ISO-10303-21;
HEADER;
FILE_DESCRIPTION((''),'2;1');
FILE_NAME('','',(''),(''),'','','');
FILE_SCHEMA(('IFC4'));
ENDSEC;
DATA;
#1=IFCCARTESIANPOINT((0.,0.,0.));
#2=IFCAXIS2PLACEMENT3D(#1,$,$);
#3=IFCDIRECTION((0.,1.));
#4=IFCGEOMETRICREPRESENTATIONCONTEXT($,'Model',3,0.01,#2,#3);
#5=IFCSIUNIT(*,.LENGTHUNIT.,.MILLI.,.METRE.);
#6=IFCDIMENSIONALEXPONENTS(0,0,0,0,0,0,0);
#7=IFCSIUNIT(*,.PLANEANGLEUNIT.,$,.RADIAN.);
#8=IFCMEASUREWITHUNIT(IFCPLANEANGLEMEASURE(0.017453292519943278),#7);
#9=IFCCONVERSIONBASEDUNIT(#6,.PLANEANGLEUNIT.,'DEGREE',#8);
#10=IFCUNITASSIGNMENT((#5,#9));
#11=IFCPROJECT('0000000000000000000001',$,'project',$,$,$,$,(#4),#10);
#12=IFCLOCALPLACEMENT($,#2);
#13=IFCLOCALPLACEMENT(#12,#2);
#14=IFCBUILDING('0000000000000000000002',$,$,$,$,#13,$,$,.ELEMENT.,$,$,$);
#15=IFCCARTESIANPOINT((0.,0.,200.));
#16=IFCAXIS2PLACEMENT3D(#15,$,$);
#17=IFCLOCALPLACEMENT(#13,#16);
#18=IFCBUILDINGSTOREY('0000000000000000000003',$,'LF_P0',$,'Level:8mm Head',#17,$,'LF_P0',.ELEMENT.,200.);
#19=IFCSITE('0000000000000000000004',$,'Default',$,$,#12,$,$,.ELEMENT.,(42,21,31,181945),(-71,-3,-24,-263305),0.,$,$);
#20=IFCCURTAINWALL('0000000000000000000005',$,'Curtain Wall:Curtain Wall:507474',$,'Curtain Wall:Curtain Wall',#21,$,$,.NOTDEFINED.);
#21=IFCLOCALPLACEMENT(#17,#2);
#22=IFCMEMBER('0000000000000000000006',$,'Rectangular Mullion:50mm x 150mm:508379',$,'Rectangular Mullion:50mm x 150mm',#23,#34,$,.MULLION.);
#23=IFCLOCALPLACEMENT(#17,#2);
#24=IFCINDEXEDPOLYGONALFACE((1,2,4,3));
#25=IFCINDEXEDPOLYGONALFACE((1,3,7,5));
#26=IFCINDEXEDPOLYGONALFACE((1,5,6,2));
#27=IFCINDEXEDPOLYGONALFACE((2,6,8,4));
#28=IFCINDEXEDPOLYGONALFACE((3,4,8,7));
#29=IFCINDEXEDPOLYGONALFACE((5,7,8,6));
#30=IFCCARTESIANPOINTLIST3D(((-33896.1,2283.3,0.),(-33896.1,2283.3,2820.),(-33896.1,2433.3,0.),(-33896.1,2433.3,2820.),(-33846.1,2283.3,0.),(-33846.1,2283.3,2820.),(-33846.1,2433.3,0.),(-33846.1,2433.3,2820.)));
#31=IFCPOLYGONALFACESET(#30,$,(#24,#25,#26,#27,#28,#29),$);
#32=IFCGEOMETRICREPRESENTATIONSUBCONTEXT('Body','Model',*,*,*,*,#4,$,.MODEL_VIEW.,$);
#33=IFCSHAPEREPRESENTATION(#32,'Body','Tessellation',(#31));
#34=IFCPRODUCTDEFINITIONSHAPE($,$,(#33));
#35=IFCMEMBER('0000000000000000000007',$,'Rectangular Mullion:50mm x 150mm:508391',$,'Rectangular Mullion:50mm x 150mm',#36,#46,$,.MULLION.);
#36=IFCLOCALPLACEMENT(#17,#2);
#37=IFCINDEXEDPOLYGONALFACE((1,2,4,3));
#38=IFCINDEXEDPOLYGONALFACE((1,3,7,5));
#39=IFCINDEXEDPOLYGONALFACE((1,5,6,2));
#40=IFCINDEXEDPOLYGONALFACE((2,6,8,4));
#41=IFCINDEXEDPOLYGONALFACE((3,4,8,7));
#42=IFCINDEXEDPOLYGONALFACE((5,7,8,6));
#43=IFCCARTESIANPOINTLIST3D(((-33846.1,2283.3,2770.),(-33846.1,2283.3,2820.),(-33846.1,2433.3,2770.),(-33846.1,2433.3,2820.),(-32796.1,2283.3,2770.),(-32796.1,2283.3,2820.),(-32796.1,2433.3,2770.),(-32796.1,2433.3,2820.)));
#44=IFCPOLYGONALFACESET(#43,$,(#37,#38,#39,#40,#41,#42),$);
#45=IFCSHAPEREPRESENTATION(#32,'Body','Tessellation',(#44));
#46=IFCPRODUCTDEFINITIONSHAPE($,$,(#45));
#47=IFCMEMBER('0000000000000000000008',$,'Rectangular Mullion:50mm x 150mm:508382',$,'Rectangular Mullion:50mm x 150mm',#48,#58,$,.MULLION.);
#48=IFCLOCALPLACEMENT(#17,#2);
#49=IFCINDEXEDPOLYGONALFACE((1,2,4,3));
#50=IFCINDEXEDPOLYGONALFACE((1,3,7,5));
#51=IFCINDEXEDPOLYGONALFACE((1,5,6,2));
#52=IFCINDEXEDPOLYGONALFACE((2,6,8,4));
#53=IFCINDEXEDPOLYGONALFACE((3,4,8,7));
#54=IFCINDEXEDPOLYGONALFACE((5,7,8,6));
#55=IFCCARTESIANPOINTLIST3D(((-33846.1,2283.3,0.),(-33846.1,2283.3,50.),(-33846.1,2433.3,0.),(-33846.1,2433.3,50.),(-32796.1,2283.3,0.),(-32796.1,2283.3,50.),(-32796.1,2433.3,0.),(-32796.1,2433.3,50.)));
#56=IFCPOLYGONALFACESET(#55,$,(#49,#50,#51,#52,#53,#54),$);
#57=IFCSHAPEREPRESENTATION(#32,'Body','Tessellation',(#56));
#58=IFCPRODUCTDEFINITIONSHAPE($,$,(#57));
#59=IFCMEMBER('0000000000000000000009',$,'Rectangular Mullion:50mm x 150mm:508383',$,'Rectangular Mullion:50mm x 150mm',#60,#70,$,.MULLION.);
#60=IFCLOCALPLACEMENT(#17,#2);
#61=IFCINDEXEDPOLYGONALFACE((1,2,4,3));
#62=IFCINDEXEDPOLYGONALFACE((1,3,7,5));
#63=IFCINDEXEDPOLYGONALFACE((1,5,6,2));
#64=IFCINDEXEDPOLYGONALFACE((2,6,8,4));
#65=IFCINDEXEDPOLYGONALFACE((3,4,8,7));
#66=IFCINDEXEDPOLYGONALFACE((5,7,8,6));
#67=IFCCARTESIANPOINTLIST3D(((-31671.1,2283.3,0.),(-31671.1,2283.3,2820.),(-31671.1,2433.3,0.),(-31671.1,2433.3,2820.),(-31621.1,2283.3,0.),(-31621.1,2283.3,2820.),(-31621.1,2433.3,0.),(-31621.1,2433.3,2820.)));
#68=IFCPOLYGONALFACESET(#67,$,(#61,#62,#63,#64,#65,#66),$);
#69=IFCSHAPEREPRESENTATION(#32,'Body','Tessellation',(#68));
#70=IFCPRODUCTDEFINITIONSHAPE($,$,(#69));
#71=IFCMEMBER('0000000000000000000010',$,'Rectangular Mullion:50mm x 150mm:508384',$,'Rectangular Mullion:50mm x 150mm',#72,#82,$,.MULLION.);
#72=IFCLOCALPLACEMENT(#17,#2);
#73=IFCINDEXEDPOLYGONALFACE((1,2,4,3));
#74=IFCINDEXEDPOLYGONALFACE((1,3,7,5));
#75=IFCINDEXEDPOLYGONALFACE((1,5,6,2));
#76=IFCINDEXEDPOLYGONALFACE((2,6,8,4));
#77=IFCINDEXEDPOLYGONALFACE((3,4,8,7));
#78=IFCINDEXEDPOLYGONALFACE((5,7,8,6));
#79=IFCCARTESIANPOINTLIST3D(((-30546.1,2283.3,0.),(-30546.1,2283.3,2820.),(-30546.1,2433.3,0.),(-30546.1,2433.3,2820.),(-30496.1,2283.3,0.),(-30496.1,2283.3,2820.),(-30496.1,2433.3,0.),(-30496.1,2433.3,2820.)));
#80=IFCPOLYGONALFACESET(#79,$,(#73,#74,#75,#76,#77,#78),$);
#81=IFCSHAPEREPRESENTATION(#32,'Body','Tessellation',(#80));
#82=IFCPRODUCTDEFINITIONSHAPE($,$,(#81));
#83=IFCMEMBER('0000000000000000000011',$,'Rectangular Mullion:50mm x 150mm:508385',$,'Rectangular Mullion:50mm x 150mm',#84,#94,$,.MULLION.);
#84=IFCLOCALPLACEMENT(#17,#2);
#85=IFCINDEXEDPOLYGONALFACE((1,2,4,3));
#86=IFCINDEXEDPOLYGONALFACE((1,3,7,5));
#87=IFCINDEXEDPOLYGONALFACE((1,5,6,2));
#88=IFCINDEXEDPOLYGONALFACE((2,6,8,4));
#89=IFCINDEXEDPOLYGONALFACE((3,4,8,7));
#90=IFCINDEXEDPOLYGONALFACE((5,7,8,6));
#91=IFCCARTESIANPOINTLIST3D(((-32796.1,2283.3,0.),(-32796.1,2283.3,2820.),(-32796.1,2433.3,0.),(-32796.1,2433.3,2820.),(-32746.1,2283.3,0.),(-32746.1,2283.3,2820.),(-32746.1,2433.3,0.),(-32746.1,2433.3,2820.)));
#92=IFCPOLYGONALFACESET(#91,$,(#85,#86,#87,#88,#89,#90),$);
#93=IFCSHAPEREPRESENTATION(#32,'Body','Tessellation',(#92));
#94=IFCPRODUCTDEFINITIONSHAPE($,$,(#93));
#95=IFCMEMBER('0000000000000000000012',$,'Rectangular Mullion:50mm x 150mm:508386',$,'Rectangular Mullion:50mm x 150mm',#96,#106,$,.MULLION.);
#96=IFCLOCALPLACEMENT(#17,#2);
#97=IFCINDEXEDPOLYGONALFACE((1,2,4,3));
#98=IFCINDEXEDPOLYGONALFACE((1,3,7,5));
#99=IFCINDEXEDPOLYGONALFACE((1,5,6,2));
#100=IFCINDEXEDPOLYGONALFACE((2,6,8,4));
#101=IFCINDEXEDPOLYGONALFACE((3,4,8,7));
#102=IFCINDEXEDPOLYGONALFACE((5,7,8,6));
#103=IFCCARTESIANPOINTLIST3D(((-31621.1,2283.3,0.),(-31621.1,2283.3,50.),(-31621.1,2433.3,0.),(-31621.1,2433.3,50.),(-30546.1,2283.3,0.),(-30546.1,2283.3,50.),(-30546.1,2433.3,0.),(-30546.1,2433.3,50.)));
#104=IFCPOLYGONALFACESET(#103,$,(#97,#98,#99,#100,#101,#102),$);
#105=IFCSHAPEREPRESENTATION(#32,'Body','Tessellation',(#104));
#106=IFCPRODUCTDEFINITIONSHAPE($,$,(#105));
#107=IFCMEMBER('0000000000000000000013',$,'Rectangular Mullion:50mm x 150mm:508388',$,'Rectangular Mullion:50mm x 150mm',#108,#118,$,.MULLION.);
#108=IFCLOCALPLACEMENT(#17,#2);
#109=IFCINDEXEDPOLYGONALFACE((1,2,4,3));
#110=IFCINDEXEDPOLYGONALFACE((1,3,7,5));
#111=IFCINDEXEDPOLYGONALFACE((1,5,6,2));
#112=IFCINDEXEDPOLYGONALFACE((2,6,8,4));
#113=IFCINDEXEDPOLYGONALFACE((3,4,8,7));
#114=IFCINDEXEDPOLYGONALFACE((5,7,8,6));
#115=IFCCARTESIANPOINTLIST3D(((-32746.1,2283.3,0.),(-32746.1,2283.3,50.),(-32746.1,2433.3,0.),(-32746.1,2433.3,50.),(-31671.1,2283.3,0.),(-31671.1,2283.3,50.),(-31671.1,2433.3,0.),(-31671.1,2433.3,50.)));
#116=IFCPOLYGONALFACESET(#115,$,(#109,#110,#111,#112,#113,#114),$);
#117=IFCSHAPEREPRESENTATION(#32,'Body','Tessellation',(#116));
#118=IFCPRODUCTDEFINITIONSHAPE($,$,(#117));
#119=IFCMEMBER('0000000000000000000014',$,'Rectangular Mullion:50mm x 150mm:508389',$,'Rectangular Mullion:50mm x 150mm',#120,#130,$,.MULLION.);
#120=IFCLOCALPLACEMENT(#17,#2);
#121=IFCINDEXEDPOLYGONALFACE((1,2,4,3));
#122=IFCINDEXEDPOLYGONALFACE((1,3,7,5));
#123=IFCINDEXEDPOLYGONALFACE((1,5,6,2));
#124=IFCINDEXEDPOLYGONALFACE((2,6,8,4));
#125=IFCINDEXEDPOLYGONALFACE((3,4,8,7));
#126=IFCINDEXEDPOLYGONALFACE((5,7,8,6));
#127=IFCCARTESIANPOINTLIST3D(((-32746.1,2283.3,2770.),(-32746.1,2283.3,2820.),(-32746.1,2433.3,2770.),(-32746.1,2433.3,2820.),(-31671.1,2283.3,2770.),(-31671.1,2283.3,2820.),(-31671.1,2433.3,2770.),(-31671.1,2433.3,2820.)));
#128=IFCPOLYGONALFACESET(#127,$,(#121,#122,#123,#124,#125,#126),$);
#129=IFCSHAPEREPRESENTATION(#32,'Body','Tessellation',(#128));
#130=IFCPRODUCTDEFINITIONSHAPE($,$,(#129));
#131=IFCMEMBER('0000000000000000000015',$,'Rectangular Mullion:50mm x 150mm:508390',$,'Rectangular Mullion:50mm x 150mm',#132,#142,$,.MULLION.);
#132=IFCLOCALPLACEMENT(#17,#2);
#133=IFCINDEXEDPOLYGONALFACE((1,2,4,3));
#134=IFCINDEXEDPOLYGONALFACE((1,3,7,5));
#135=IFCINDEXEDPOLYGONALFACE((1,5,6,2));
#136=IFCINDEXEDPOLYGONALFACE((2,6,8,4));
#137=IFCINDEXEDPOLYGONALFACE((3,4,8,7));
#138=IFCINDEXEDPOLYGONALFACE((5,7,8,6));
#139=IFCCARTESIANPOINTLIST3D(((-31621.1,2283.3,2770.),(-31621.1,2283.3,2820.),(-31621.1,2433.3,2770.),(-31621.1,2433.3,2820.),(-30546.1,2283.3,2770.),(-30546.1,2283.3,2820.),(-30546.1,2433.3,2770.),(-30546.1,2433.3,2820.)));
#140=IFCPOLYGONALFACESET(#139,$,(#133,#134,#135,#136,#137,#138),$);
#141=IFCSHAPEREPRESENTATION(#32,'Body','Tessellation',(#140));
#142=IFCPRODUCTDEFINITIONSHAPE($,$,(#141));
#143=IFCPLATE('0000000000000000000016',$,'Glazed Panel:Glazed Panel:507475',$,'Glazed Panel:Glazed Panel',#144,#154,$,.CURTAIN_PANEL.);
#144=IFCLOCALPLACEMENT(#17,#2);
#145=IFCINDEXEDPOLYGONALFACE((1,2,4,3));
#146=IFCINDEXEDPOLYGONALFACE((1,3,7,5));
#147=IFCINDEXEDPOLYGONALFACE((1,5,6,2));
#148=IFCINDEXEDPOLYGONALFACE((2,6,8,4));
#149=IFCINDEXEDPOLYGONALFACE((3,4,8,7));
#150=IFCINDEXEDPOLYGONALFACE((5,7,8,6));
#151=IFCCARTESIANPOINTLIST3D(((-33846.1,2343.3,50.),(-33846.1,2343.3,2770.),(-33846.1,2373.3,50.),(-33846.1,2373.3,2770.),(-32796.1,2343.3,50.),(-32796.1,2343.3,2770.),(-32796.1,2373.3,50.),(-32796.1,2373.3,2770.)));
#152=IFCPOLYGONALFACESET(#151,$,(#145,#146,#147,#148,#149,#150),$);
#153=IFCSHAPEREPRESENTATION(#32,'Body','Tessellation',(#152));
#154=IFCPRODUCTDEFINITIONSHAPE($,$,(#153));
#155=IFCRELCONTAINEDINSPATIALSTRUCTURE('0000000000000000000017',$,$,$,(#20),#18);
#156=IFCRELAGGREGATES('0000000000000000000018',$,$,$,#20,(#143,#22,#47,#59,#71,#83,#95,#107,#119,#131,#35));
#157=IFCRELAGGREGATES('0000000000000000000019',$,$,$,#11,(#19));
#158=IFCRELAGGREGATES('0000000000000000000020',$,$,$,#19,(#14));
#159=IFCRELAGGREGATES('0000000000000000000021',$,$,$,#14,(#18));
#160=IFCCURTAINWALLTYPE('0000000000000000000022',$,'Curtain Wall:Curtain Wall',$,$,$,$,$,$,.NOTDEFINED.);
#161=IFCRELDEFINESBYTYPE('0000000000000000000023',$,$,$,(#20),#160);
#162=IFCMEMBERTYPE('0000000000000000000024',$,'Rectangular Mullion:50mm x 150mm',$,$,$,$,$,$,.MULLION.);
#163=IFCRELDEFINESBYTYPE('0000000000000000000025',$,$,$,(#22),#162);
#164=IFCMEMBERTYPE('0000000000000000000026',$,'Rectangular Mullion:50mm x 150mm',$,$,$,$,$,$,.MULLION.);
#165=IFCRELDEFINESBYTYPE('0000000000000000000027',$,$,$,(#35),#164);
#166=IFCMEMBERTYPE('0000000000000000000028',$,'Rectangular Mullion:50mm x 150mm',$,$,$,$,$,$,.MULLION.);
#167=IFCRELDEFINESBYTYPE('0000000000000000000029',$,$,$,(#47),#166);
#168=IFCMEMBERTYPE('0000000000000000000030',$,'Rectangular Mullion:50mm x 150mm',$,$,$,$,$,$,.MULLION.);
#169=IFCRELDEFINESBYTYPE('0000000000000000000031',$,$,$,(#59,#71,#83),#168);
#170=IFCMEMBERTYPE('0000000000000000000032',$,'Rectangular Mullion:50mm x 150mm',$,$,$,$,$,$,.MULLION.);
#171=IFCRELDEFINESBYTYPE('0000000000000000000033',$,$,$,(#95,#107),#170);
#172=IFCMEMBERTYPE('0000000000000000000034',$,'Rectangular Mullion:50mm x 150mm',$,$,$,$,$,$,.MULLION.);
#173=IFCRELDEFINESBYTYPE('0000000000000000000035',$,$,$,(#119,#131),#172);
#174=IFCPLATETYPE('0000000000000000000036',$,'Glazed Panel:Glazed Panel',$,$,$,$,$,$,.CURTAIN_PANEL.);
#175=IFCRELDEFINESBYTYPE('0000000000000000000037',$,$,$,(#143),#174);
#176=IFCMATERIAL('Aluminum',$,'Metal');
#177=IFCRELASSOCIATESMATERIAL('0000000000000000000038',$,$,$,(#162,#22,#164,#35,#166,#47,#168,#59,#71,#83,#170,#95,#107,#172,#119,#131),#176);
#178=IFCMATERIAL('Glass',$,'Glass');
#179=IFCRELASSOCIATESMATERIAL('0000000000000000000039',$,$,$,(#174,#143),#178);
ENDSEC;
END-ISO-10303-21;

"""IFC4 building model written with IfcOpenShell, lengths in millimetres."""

from ifc_helpers import new_model, entity, si_unit, converted_unit, direction, frame, origin, place, context, subcontext, project, spatial, indexed_curve, outline, extrude, source, transform, mapped, material, type_object, type_shapes, element, aggregate, save


model = new_model("IFC4")

# Units and contexts
model_context = context("Model", 3, precision=0.01, world=origin(), true_north=direction((0.0, 1.0)))
body_context = subcontext(model_context, "Body", "Model", "MODEL_VIEW")
ifc_project = project(units=[si_unit("LENGTHUNIT", "METRE", prefix="MILLI"), converted_unit("PLANEANGLEUNIT", "DEGREE", entity("IfcPlaneAngleMeasure", 0.017453292519943278), si_unit("PLANEANGLEUNIT", "RADIAN"), dimensions=[0, 0, 0, 0, 0, 0, 0])], contexts=[model_context])

# Site, building, storey
site_placement = place(None, origin())
site = spatial("IfcSite", under=ifc_project, at=site_placement, Name="Default", CompositionType="ELEMENT", RefLatitude=(42, 21, 31, 181945), RefLongitude=(-71, -3, -24, -263305), RefElevation=0.0)
building_placement = place(site_placement, origin())
building = spatial("IfcBuilding", under=site, at=building_placement, CompositionType="ELEMENT")
storey_placement = place(building_placement, frame((0.0, 0.0, 200.0)))
storey = spatial("IfcBuildingStorey", under=building, at=storey_placement, Name="LF_P0", ObjectType="Level:8mm Head", LongName="LF_P0", CompositionType="ELEMENT", Elevation=200.0)

# Curtain wall, members, plate
curtain_wall_type = type_object("IfcCurtainWallType", Name="Curtain Wall:Curtain Wall", PredefinedType="NOTDEFINED")
curtain_wall_placement = place(storey_placement, frame((0.0, 0.0, -200.0)))
curtain_wall = element("IfcCurtainWall", 1, at=curtain_wall_placement, inside=storey, type_object=curtain_wall_type, Name="Curtain Wall:Curtain Wall:507474", ObjectType="Curtain Wall:Curtain Wall", PredefinedType="NOTDEFINED")
ifc_material_1 = material(Name="Aluminum", Category="Metal")
member_type_1 = type_object("IfcMemberType", Name="Rectangular Mullion:50mm x 150mm", PredefinedType="MULLION", material=ifc_material_1)
shared_shape_1 = source(origin(), body_context, "Body", "SweptSolid", [
    extrude(outline(indexed_curve([(-25.0, -75.0), (25.0, -75.0), (25.0, 75.0), (-25.0, 75.0), (-25.0, -75.0)], self_intersect=False)), frame((-25.0, 0.0, -2820.0), z_axis=(0.0, 0.0, 1.0), x_axis=(-1.0, 0.0, 0.0)), (0.0, 0.0, 1.0), 2820.0),
])
type_shapes(member_type_1, [shared_shape_1])
member_1_placement = place(curtain_wall_placement, frame((-33896.1, 2358.3, 3020.0), z_axis=(0.0, 0.0, 1.0), x_axis=(-1.0, 0.0, 0.0)))
member_1 = element("IfcMember", 2, at=member_1_placement, type_object=member_type_1, material=ifc_material_1, Name="Rectangular Mullion:50mm x 150mm:508379", ObjectType="Rectangular Mullion:50mm x 150mm", PredefinedType="MULLION", context=body_context, shape_type="MappedRepresentation", body=[
    mapped(shared_shape_1, transform((0.0, 0.0, 0.0), scale=1.0)),
])
member_type_2 = type_object("IfcMemberType", Name="Rectangular Mullion:50mm x 150mm", PredefinedType="MULLION", material=ifc_material_1)
shared_shape_2 = source(origin(), body_context, "Body", "SweptSolid", [
    extrude(outline(indexed_curve([(-25.0, -75.0), (25.0, -75.0), (25.0, 75.0), (-25.0, 75.0), (-25.0, -75.0)], self_intersect=False)), frame((-25.0, 0.0, -1050.0), z_axis=(0.0, 0.0, 1.0), x_axis=(-1.0, 0.0, 0.0)), (0.0, 0.0, 1.0), 1050.0),
])
type_shapes(member_type_2, [shared_shape_2])
member_2_placement = place(curtain_wall_placement, frame((-32796.1, 2358.3, 3020.0), z_axis=(1.0, 0.0, 0.0), x_axis=(0.0, 0.0, 1.0)))
member_2 = element("IfcMember", 3, at=member_2_placement, type_object=member_type_2, material=ifc_material_1, Name="Rectangular Mullion:50mm x 150mm:508391", ObjectType="Rectangular Mullion:50mm x 150mm", PredefinedType="MULLION", context=body_context, shape_type="MappedRepresentation", body=[
    mapped(shared_shape_2, transform((0.0, 0.0, 0.0), scale=1.0)),
])
member_type_3 = type_object("IfcMemberType", Name="Rectangular Mullion:50mm x 150mm", PredefinedType="MULLION", material=ifc_material_1)
shared_shape_3 = source(origin(), body_context, "Body", "SweptSolid", [
    extrude(outline(indexed_curve([(-25.0, -75.0), (25.0, -75.0), (25.0, 75.0), (-25.0, 75.0), (-25.0, -75.0)], self_intersect=False)), frame((-25.0, 0.0, -1050.0), z_axis=(0.0, 0.0, 1.0), x_axis=(-1.0, 0.0, 0.0)), (0.0, 0.0, 1.0), 1050.0),
])
type_shapes(member_type_3, [shared_shape_3])
member_3_placement = place(curtain_wall_placement, frame((-33846.1, 2358.3, 200.0), z_axis=(-1.0, 0.0, 0.0), x_axis=(0.0, 0.0, -1.0)))
member_3 = element("IfcMember", 4, at=member_3_placement, type_object=member_type_3, material=ifc_material_1, Name="Rectangular Mullion:50mm x 150mm:508382", ObjectType="Rectangular Mullion:50mm x 150mm", PredefinedType="MULLION", context=body_context, shape_type="MappedRepresentation", body=[
    mapped(shared_shape_3, transform((0.0, 0.0, 0.0), scale=1.0)),
])
member_type_4 = type_object("IfcMemberType", Name="Rectangular Mullion:50mm x 150mm", PredefinedType="MULLION", material=ifc_material_1)
shared_shape_4 = source(origin(), body_context, "Body", "SweptSolid", [
    extrude(outline(indexed_curve([(-25.0, -75.0), (25.0, -75.0), (25.0, 75.0), (-25.0, 75.0), (-25.0, -75.0)], self_intersect=False)), frame((0.0, 0.0, -2820.0), z_axis=(0.0, 0.0, 1.0), x_axis=(-1.0, 0.0, 0.0)), (0.0, 0.0, 1.0), 2820.0),
])
type_shapes(member_type_4, [shared_shape_4])
member_4_placement = place(curtain_wall_placement, frame((-31646.1, 2358.3, 200.0), z_axis=(0.0, 0.0, -1.0), x_axis=(1.0, 0.0, 0.0)))
member_4 = element("IfcMember", 5, at=member_4_placement, type_object=member_type_4, material=ifc_material_1, Name="Rectangular Mullion:50mm x 150mm:508383", ObjectType="Rectangular Mullion:50mm x 150mm", PredefinedType="MULLION", context=body_context, shape_type="MappedRepresentation", body=[
    mapped(shared_shape_4, transform((0.0, 0.0, 0.0), scale=1.0)),
])
member_5_placement = place(curtain_wall_placement, frame((-30521.1, 2358.3, 200.0), z_axis=(0.0, 0.0, -1.0), x_axis=(1.0, 0.0, 0.0)))
member_5 = element("IfcMember", 6, at=member_5_placement, type_object=member_type_4, material=ifc_material_1, Name="Rectangular Mullion:50mm x 150mm:508384", ObjectType="Rectangular Mullion:50mm x 150mm", PredefinedType="MULLION", context=body_context, shape_type="MappedRepresentation", body=[
    mapped(shared_shape_4, transform((0.0, 0.0, 0.0), scale=1.0)),
])
member_6_placement = place(curtain_wall_placement, frame((-32771.1, 2358.3, 200.0), z_axis=(0.0, 0.0, -1.0), x_axis=(1.0, 0.0, 0.0)))
member_6 = element("IfcMember", 7, at=member_6_placement, type_object=member_type_4, material=ifc_material_1, Name="Rectangular Mullion:50mm x 150mm:508385", ObjectType="Rectangular Mullion:50mm x 150mm", PredefinedType="MULLION", context=body_context, shape_type="MappedRepresentation", body=[
    mapped(shared_shape_4, transform((0.0, 0.0, 0.0), scale=1.0)),
])
member_type_5 = type_object("IfcMemberType", Name="Rectangular Mullion:50mm x 150mm", PredefinedType="MULLION", material=ifc_material_1)
shared_shape_5 = source(origin(), body_context, "Body", "SweptSolid", [
    extrude(outline(indexed_curve([(-25.0, -75.0), (25.0, -75.0), (25.0, 75.0), (-25.0, 75.0), (-25.0, -75.0)], self_intersect=False)), frame((-25.0, 0.0, -1075.0), z_axis=(0.0, 0.0, 1.0), x_axis=(-1.0, 0.0, 0.0)), (0.0, 0.0, 1.0), 1075.0),
])
type_shapes(member_type_5, [shared_shape_5])
member_7_placement = place(curtain_wall_placement, frame((-31621.1, 2358.3, 200.0), z_axis=(-1.0, 0.0, 0.0), x_axis=(0.0, 0.0, -1.0)))
member_7 = element("IfcMember", 8, at=member_7_placement, type_object=member_type_5, material=ifc_material_1, Name="Rectangular Mullion:50mm x 150mm:508386", ObjectType="Rectangular Mullion:50mm x 150mm", PredefinedType="MULLION", context=body_context, shape_type="MappedRepresentation", body=[
    mapped(shared_shape_5, transform((0.0, 0.0, 0.0), scale=1.0)),
])
member_8_placement = place(curtain_wall_placement, frame((-32746.1, 2358.3, 200.0), z_axis=(-1.0, 0.0, 0.0), x_axis=(0.0, 0.0, -1.0)))
member_8 = element("IfcMember", 9, at=member_8_placement, type_object=member_type_5, material=ifc_material_1, Name="Rectangular Mullion:50mm x 150mm:508388", ObjectType="Rectangular Mullion:50mm x 150mm", PredefinedType="MULLION", context=body_context, shape_type="MappedRepresentation", body=[
    mapped(shared_shape_5, transform((0.0, 0.0, 0.0), scale=1.0)),
])
member_type_6 = type_object("IfcMemberType", Name="Rectangular Mullion:50mm x 150mm", PredefinedType="MULLION", material=ifc_material_1)
shared_shape_6 = source(origin(), body_context, "Body", "SweptSolid", [
    extrude(outline(indexed_curve([(-25.0, -75.0), (25.0, -75.0), (25.0, 75.0), (-25.0, 75.0), (-25.0, -75.0)], self_intersect=False)), frame((-25.0, 0.0, -1075.0), z_axis=(0.0, 0.0, 1.0), x_axis=(-1.0, 0.0, 0.0)), (0.0, 0.0, 1.0), 1075.0),
])
type_shapes(member_type_6, [shared_shape_6])
member_9_placement = place(curtain_wall_placement, frame((-31671.1, 2358.3, 3020.0), z_axis=(1.0, 0.0, 0.0), x_axis=(0.0, 0.0, 1.0)))
member_9 = element("IfcMember", 10, at=member_9_placement, type_object=member_type_6, material=ifc_material_1, Name="Rectangular Mullion:50mm x 150mm:508389", ObjectType="Rectangular Mullion:50mm x 150mm", PredefinedType="MULLION", context=body_context, shape_type="MappedRepresentation", body=[
    mapped(shared_shape_6, transform((0.0, 0.0, 0.0), scale=1.0)),
])
member_10_placement = place(curtain_wall_placement, frame((-30546.1, 2358.3, 3020.0), z_axis=(1.0, 0.0, 0.0), x_axis=(0.0, 0.0, 1.0)))
member_10 = element("IfcMember", 11, at=member_10_placement, type_object=member_type_6, material=ifc_material_1, Name="Rectangular Mullion:50mm x 150mm:508390", ObjectType="Rectangular Mullion:50mm x 150mm", PredefinedType="MULLION", context=body_context, shape_type="MappedRepresentation", body=[
    mapped(shared_shape_6, transform((0.0, 0.0, 0.0), scale=1.0)),
])
ifc_material_2 = material(Name="Glass", Category="Glass")
plate_type_1 = type_object("IfcPlateType", Name="Glazed Panel:Glazed Panel", PredefinedType="CURTAIN_PANEL", material=ifc_material_2)
shared_shape_7 = source(origin(), body_context, "Body", "SweptSolid", [
    extrude(outline(indexed_curve([(-15.0, -525.0), (15.0, -525.0), (15.0, 525.0), (-15.0, 525.0), (-15.0, -525.0)], self_intersect=False)), frame((0.0, 0.0, 0.0), z_axis=(0.0, 0.0, 1.0), x_axis=(0.0, 1.0, 0.0)), (0.0, 0.0, 1.0), 2720.0),
])
type_shapes(plate_type_1, [shared_shape_7])
plate_1_placement = place(curtain_wall_placement, frame((-33321.1, 2358.3, 250.0)))
plate_1 = element("IfcPlate", 12, at=plate_1_placement, type_object=plate_type_1, material=ifc_material_2, Name="Glazed Panel:Glazed Panel:507475", ObjectType="Glazed Panel:Glazed Panel", PredefinedType="CURTAIN_PANEL", context=body_context, shape_type="MappedRepresentation", body=[
    mapped(shared_shape_7, transform((0.0, 0.0, 0.0), scale=1.0)),
])
aggregate(curtain_wall, [plate_1, member_1, member_3, member_4, member_5, member_6, member_7, member_8, member_9, member_10, member_2])

save(model, "model.ifc")
